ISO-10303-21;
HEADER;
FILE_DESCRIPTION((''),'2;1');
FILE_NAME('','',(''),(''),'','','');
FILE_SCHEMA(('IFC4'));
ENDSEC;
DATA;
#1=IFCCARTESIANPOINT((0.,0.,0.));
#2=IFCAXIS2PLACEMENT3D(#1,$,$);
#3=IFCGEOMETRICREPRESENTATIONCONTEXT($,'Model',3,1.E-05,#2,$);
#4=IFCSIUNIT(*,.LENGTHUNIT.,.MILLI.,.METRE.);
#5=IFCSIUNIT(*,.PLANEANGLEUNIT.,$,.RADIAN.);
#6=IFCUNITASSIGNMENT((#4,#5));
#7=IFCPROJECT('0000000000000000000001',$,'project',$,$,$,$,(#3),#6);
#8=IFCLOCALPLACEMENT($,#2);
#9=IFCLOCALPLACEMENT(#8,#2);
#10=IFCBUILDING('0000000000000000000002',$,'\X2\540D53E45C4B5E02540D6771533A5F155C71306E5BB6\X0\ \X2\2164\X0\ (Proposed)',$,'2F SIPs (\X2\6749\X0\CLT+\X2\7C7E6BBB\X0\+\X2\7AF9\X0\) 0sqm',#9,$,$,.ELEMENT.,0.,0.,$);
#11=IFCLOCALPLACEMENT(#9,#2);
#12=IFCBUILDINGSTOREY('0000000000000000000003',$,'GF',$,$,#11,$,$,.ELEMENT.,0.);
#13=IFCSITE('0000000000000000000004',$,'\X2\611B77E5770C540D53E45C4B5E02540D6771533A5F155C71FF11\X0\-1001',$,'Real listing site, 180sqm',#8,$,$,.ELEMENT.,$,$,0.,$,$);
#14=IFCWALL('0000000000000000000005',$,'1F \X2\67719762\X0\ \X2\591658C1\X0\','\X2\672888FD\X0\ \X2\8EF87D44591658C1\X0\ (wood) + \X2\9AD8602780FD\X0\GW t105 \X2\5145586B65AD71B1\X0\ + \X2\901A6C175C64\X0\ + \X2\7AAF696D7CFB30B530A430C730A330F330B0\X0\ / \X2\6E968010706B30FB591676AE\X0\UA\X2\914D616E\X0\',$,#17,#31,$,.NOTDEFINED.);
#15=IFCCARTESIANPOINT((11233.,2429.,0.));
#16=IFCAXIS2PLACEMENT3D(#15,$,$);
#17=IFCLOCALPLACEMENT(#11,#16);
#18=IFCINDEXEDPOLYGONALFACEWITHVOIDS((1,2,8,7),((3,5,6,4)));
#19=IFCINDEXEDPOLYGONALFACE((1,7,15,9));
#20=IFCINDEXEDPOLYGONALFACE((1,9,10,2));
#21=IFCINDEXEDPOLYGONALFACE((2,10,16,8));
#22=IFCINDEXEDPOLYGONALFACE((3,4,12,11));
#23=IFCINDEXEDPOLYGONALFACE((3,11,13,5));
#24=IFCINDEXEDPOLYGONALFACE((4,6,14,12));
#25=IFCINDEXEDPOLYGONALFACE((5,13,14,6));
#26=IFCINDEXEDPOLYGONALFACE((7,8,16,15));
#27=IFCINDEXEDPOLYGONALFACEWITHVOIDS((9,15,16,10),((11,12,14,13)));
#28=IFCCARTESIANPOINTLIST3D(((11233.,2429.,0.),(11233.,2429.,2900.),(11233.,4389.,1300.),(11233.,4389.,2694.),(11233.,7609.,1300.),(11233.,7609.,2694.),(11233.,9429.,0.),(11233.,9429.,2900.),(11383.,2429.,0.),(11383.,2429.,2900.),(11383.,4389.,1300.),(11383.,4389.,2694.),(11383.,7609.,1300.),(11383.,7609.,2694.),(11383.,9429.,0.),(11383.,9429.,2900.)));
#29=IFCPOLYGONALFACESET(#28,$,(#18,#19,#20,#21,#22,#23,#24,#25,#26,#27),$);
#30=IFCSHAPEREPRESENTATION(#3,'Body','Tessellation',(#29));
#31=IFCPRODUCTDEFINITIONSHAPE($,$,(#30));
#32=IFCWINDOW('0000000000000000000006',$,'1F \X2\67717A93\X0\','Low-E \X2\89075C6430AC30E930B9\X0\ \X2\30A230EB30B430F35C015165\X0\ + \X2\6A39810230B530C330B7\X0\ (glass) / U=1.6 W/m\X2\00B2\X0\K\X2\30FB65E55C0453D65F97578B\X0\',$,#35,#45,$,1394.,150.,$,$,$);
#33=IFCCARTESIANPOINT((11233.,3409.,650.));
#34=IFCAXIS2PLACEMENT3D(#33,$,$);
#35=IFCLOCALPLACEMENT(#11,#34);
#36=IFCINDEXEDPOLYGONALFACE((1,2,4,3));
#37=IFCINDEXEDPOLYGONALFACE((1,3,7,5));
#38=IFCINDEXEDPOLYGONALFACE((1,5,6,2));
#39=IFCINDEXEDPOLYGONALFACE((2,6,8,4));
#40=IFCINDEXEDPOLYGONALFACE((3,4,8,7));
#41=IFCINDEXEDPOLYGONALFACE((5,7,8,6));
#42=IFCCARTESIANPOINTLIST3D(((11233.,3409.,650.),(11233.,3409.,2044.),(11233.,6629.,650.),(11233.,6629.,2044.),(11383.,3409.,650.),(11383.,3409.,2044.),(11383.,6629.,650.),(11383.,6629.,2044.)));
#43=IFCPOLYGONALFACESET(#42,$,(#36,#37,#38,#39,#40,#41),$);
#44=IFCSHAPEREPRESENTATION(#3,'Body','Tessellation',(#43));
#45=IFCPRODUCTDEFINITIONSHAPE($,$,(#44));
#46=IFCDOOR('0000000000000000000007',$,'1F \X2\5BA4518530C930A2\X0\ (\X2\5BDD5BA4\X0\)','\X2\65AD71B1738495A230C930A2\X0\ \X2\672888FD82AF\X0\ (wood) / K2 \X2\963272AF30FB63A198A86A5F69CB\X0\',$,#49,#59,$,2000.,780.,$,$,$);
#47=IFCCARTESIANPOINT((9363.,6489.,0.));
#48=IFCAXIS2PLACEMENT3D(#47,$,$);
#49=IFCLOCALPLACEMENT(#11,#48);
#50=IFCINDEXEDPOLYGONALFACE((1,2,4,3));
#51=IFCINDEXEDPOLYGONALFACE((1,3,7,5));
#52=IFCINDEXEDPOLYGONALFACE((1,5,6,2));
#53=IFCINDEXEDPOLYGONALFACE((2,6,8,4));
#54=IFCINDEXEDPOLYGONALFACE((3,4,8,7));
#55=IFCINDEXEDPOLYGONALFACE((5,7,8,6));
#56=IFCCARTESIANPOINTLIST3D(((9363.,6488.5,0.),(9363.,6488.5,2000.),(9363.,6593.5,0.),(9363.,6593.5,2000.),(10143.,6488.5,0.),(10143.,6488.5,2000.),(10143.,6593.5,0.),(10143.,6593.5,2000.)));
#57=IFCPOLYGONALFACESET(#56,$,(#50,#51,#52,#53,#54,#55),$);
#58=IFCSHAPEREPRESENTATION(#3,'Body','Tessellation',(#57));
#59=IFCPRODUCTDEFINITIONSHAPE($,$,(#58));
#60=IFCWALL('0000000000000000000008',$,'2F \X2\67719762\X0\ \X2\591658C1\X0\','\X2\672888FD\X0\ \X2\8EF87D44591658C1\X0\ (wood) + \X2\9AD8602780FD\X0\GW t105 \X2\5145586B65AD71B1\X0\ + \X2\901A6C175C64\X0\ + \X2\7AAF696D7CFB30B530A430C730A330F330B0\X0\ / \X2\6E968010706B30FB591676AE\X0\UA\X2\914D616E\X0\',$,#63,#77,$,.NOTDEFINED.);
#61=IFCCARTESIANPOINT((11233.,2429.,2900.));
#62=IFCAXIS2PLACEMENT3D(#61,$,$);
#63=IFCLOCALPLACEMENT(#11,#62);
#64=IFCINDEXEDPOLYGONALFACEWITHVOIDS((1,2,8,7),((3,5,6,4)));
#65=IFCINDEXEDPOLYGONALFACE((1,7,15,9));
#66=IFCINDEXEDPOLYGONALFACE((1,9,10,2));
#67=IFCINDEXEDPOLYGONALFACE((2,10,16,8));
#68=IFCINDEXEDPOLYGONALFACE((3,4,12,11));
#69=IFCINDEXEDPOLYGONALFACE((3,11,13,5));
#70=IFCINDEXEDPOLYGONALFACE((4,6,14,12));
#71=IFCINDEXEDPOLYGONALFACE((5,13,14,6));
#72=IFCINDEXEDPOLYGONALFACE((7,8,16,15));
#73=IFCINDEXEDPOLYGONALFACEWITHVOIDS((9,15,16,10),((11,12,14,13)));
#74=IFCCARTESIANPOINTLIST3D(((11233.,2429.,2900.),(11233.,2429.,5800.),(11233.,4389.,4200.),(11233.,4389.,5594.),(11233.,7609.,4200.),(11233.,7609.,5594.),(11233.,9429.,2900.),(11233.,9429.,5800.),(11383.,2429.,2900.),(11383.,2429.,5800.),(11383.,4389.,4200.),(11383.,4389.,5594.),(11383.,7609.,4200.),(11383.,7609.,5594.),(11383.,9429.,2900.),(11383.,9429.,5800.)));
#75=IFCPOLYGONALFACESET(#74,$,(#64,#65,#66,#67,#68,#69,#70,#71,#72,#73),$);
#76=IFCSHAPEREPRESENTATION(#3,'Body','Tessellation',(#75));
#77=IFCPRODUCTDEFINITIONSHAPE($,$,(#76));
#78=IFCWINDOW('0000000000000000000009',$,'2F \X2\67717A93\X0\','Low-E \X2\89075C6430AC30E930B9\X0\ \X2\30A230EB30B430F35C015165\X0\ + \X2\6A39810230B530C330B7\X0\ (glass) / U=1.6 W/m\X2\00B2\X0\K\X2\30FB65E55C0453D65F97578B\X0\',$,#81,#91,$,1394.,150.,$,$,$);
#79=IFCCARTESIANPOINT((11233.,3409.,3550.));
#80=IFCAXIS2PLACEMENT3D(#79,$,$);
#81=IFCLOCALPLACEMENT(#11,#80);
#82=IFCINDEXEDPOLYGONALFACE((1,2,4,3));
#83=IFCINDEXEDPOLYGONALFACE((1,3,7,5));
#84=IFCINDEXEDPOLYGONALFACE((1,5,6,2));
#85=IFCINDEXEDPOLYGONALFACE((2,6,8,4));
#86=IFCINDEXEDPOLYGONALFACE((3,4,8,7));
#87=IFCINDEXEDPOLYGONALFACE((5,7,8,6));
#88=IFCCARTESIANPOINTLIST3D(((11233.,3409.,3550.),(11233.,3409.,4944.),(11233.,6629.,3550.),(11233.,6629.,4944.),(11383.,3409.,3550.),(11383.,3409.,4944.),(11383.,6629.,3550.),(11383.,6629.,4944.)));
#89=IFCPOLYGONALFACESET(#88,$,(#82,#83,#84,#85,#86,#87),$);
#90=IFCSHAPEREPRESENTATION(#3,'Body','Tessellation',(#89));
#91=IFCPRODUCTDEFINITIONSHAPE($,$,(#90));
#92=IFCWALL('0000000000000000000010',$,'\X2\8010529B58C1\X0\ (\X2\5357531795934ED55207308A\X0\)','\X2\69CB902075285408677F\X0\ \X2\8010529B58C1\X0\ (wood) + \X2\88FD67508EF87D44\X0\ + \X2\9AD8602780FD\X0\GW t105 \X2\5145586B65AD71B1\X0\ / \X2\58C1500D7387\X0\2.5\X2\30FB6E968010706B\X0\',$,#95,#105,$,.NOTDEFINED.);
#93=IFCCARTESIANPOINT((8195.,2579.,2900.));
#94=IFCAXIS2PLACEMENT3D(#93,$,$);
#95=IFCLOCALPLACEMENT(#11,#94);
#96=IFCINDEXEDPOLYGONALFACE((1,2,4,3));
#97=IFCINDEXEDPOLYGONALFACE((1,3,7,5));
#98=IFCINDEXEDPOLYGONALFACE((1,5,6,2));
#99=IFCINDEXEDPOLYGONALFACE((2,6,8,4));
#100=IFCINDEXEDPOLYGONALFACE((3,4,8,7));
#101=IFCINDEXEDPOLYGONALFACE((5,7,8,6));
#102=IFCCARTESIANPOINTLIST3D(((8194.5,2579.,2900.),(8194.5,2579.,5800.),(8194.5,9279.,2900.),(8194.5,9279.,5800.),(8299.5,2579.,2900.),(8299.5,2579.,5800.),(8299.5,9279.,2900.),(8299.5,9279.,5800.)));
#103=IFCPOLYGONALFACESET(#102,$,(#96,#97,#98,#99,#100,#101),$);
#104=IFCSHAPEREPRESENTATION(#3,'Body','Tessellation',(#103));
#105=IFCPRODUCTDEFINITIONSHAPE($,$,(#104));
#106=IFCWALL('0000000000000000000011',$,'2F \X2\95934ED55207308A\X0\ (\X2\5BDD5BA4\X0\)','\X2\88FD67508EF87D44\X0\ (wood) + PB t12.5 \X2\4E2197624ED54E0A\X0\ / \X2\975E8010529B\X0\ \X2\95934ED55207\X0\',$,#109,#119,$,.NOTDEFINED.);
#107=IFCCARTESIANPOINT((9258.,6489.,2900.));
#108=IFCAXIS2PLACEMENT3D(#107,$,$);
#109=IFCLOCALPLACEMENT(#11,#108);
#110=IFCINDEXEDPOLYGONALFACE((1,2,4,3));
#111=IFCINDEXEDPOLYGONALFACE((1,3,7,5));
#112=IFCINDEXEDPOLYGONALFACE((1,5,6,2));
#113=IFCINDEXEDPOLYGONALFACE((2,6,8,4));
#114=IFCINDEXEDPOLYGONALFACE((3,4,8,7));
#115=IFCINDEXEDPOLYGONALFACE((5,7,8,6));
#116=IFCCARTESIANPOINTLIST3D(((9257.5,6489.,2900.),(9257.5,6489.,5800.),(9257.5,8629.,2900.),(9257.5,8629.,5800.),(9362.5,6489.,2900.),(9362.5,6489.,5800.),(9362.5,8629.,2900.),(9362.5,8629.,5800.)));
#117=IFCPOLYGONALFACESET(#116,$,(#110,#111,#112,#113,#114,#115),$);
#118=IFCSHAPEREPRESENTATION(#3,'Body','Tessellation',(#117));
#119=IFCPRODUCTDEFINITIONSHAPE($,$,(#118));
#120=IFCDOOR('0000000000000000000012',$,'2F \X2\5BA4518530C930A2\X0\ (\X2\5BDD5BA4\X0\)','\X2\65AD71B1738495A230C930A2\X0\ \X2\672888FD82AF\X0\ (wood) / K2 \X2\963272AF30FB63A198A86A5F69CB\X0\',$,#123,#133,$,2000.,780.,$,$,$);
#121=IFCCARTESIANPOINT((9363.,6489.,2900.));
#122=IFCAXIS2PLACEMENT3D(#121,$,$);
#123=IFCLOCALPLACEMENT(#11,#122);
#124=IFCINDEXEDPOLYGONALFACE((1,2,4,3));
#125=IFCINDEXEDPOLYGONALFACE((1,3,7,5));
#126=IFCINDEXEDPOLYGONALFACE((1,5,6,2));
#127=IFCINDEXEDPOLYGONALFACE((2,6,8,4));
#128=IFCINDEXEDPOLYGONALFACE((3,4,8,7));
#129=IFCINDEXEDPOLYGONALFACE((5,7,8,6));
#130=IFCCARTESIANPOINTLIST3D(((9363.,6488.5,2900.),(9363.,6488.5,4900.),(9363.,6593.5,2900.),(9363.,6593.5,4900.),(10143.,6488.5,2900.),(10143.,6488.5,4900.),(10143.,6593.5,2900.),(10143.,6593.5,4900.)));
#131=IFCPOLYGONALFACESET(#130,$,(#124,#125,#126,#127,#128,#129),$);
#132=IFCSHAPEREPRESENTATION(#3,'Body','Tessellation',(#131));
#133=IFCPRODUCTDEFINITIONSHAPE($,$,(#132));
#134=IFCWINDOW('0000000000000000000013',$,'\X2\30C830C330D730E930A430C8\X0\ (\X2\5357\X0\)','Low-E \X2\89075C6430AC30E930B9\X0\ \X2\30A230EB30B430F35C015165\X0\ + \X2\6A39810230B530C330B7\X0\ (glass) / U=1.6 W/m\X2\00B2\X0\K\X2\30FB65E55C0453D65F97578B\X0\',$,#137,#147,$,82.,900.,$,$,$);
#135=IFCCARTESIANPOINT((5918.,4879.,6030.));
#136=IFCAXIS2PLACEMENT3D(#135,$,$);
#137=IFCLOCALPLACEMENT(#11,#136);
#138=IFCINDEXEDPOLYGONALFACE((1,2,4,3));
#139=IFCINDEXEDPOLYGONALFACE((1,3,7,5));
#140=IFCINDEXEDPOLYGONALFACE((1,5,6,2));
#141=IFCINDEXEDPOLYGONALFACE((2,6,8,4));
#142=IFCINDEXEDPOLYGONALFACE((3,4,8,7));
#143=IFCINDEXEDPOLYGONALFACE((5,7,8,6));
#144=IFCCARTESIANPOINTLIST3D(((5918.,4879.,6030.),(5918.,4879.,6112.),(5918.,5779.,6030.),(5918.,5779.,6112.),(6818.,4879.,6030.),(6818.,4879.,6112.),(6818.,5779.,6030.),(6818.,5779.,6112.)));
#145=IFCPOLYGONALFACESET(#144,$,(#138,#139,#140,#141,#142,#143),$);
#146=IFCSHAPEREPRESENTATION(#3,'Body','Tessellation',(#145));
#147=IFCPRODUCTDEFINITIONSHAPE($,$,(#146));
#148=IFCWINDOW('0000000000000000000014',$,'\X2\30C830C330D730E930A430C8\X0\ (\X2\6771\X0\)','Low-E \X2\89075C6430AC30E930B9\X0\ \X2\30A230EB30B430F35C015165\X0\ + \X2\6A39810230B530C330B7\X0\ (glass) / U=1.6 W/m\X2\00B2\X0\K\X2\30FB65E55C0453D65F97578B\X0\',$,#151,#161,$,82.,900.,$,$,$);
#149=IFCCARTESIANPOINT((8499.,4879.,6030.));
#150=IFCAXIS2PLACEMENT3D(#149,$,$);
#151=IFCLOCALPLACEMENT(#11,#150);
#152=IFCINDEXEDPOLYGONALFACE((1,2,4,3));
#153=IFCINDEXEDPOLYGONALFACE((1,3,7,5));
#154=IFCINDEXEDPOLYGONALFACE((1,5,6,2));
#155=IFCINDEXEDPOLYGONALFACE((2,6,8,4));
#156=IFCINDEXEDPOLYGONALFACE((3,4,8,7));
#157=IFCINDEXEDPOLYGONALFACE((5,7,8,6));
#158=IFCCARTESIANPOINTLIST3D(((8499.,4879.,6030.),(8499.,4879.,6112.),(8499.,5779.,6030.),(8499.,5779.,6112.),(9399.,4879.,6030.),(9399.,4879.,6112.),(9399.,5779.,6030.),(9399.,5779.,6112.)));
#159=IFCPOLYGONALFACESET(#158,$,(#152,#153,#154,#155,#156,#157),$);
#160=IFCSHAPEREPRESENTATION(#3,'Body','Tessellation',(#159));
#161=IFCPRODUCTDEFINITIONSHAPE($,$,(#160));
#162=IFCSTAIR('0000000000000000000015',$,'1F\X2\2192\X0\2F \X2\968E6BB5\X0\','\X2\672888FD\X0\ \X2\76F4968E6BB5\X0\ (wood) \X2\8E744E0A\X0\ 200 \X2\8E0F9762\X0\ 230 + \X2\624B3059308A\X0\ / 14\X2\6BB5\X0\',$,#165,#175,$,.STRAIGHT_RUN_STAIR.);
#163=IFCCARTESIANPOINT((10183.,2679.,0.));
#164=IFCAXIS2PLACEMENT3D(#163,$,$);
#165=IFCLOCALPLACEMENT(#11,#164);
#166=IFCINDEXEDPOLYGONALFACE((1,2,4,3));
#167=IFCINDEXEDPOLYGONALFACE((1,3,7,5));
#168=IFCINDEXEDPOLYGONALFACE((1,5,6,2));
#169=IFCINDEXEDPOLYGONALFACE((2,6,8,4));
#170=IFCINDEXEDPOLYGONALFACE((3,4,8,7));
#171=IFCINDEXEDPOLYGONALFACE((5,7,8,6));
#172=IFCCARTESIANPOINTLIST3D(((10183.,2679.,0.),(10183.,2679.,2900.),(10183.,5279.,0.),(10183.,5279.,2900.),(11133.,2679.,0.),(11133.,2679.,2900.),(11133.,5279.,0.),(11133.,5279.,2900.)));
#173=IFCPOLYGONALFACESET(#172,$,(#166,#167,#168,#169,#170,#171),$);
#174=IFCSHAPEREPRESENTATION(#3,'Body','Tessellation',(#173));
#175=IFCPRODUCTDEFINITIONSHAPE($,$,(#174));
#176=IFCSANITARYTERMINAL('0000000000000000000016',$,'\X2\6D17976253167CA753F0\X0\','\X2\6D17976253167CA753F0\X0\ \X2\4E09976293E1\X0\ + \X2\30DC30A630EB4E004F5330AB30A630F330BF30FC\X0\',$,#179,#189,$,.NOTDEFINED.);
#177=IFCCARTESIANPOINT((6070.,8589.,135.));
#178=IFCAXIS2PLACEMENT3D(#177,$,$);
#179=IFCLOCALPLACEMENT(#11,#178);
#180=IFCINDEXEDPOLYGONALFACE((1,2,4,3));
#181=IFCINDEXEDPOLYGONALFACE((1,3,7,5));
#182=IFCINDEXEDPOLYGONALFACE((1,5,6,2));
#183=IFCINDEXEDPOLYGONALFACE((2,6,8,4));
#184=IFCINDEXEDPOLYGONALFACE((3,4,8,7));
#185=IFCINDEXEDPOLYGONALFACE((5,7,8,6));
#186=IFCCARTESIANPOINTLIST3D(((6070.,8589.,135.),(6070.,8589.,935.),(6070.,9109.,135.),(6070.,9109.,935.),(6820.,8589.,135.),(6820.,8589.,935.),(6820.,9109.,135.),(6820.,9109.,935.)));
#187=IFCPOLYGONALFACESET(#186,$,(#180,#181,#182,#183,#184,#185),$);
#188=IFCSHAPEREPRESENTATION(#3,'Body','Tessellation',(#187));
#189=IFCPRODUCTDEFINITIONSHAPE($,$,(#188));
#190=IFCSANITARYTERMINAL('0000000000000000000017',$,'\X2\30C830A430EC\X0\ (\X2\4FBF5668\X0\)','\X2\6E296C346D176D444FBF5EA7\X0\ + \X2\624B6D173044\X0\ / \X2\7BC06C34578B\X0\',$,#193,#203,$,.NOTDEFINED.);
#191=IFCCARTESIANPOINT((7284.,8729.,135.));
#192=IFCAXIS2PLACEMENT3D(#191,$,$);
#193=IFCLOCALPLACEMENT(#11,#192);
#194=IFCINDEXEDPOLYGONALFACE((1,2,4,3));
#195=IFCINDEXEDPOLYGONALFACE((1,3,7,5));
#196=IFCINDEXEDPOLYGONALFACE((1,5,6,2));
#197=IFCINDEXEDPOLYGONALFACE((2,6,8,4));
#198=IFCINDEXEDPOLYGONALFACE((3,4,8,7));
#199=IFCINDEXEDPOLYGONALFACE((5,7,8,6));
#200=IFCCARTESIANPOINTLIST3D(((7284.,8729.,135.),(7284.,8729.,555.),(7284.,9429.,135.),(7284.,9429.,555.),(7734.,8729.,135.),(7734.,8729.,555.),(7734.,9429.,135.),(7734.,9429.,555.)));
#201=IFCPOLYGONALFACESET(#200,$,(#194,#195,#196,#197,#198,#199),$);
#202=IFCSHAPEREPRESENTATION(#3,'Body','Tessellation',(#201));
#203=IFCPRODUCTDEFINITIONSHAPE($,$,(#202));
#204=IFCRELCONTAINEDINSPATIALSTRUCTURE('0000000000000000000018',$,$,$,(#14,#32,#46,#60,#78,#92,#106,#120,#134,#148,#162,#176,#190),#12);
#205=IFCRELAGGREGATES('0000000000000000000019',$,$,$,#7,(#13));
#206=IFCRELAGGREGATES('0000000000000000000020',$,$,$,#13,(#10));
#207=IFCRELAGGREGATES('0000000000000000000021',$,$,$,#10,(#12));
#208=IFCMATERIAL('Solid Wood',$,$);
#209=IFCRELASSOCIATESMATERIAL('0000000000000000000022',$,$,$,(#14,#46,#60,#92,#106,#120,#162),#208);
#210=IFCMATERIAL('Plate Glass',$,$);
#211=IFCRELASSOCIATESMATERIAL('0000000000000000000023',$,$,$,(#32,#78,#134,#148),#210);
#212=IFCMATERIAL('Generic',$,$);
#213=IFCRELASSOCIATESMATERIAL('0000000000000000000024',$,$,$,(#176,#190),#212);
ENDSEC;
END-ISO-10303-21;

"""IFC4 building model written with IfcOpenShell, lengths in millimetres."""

from ifc_helpers import new_model, si_unit, frame, frame_2d, origin, place, context, project, spatial, rectangle, extrude, material, element, fill, save


model = new_model("IFC4")

# Units and contexts
model_context = context("Model", 3, precision=1e-05, world=origin())
ifc_project = project(units=[si_unit("LENGTHUNIT", "METRE", prefix="MILLI"), si_unit("PLANEANGLEUNIT", "RADIAN")], contexts=[model_context])

# Site, building, storey
site_placement = place(None, origin())
site = spatial("IfcSite", under=ifc_project, at=site_placement, Name="愛知県名古屋市名東区引山１-1001", ObjectType="Real listing site, 180sqm", CompositionType="ELEMENT", RefElevation=0.0)
building_placement = place(site_placement, origin())
building = spatial("IfcBuilding", under=site, at=building_placement, Name="名古屋市名東区引山の家 Ⅴ (Proposed)", ObjectType="2F SIPs (杉CLT+籾殻+竹) 0sqm", CompositionType="ELEMENT", ElevationOfRefHeight=0.0, ElevationOfTerrain=0.0)
storey_placement = place(building_placement, origin())
storey = spatial("IfcBuildingStorey", under=building, at=storey_placement, Name="GF", CompositionType="ELEMENT", Elevation=0.0)

# Wall, opening, window
ifc_material_1 = material(Name="Solid Wood")
wall_1_placement = place(storey_placement, frame((11233.0, 2429.0, 0.0)))
wall_1 = element("IfcWall", 1, at=wall_1_placement, inside=storey, material=ifc_material_1, Name="1F 東面 外壁", Description="木製 軸組外壁 (wood) + 高性能GW t105 充填断熱 + 通気層 + 窯業系サイディング / 準耐火・外皮UA配慮", PredefinedType="NOTDEFINED", context=model_context, shape_type="SweptSolid", body=[
    extrude(rectangle(XDim=150.0, YDim=7000.0, at=frame_2d((75.0, 3500.0))), frame((11233.0, 2429.0, 0.0)), (0.0, 0.0, 1.0), 2900.0),
])
opening_1_placement = place(storey_placement, frame((11233.0, 3409.0, 650.0)))
opening_1 = element("IfcOpeningElement", 2, at=opening_1_placement, cuts=wall_1, PredefinedType="NOTDEFINED", context=model_context, shape_type="SweptSolid", body=[
    extrude(rectangle(XDim=150.0, YDim=3220.0, at=frame_2d((75.0, 1610.0))), frame((11233.0, 3409.0, 650.0)), (0.0, 0.0, 1.0), 1394.0),
])
ifc_material_2 = material(Name="Plate Glass")
window_1_placement = place(storey_placement, frame((11233.0, 3409.0, 650.0)))
window_1 = element("IfcWindow", 3, at=window_1_placement, inside=storey, material=ifc_material_2, Name="1F 東窓", Description="Low-E 複層ガラス アルゴン封入 + 樹脂サッシ (glass) / U=1.6 W/m²K・日射取得型", OverallHeight=1394.0, OverallWidth=150.0, context=model_context, shape_type="SweptSolid", body=[
    extrude(rectangle(XDim=150.0, YDim=3220.0, at=frame_2d((75.0, 1610.0))), frame((11233.0, 3409.0, 650.0)), (0.0, 0.0, 1.0), 1394.0),
])
fill(opening_1, window_1)

# Door
door_1_placement = place(storey_placement, frame((9363.0, 6489.0, 0.0)))
element("IfcDoor", 4, at=door_1_placement, inside=storey, material=ifc_material_1, Name="1F 室内ドア (寝室)", Description="断熱玄関ドア 木製芯 (wood) / K2 防犯・採風機構", OverallHeight=2000.0, OverallWidth=780.0, context=model_context, shape_type="SweptSolid", body=[
    extrude(rectangle(XDim=780.0, YDim=105.0, at=frame_2d((390.0, 52.0))), frame((9363.0, 6489.0, 0.0)), (0.0, 0.0, 1.0), 2000.0),
])

# Wall, opening, window
wall_2_placement = place(storey_placement, frame((11233.0, 2429.0, 2900.0)))
wall_2 = element("IfcWall", 5, at=wall_2_placement, inside=storey, material=ifc_material_1, Name="2F 東面 外壁", Description="木製 軸組外壁 (wood) + 高性能GW t105 充填断熱 + 通気層 + 窯業系サイディング / 準耐火・外皮UA配慮", PredefinedType="NOTDEFINED", context=model_context, shape_type="SweptSolid", body=[
    extrude(rectangle(XDim=150.0, YDim=7000.0, at=frame_2d((75.0, 3500.0))), frame((11233.0, 2429.0, 2900.0)), (0.0, 0.0, 1.0), 2900.0),
])
opening_2_placement = place(storey_placement, frame((11233.0, 3409.0, 3550.0)))
opening_2 = element("IfcOpeningElement", 6, at=opening_2_placement, cuts=wall_2, PredefinedType="NOTDEFINED", context=model_context, shape_type="SweptSolid", body=[
    extrude(rectangle(XDim=150.0, YDim=3220.0, at=frame_2d((75.0, 1610.0))), frame((11233.0, 3409.0, 3550.0)), (0.0, 0.0, 1.0), 1394.0),
])
window_2_placement = place(storey_placement, frame((11233.0, 3409.0, 3550.0)))
window_2 = element("IfcWindow", 7, at=window_2_placement, inside=storey, material=ifc_material_2, Name="2F 東窓", Description="Low-E 複層ガラス アルゴン封入 + 樹脂サッシ (glass) / U=1.6 W/m²K・日射取得型", OverallHeight=1394.0, OverallWidth=150.0, context=model_context, shape_type="SweptSolid", body=[
    extrude(rectangle(XDim=150.0, YDim=3220.0, at=frame_2d((75.0, 1610.0))), frame((11233.0, 3409.0, 3550.0)), (0.0, 0.0, 1.0), 1394.0),
])
fill(opening_2, window_2)

# Walls
wall_3_placement = place(storey_placement, frame((8195.0, 2579.0, 2900.0)))
element("IfcWall", 8, at=wall_3_placement, inside=storey, material=ifc_material_1, Name="耐力壁 (南北間仕切り)", Description="構造用合板 耐力壁 (wood) + 製材軸組 + 高性能GW t105 充填断熱 / 壁倍率2.5・準耐火", PredefinedType="NOTDEFINED", context=model_context, shape_type="SweptSolid", body=[
    extrude(rectangle(XDim=105.0, YDim=6700.0, at=frame_2d((52.0, 3350.0))), frame((8195.0, 2579.0, 2900.0)), (0.0, 0.0, 1.0), 2900.0),
])
wall_4_placement = place(storey_placement, frame((9258.0, 6489.0, 2900.0)))
element("IfcWall", 9, at=wall_4_placement, inside=storey, material=ifc_material_1, Name="2F 間仕切り (寝室)", Description="製材軸組 (wood) + PB t12.5 両面仕上 / 非耐力 間仕切", PredefinedType="NOTDEFINED", context=model_context, shape_type="SweptSolid", body=[
    extrude(rectangle(XDim=105.0, YDim=2140.0, at=frame_2d((52.0, 1070.0))), frame((9258.0, 6489.0, 2900.0)), (0.0, 0.0, 1.0), 2900.0),
])

# Door
door_2_placement = place(storey_placement, frame((9363.0, 6489.0, 2900.0)))
element("IfcDoor", 10, at=door_2_placement, inside=storey, material=ifc_material_1, Name="2F 室内ドア (寝室)", Description="断熱玄関ドア 木製芯 (wood) / K2 防犯・採風機構", OverallHeight=2000.0, OverallWidth=780.0, context=model_context, shape_type="SweptSolid", body=[
    extrude(rectangle(XDim=780.0, YDim=105.0, at=frame_2d((390.0, 52.0))), frame((9363.0, 6489.0, 2900.0)), (0.0, 0.0, 1.0), 2000.0),
])

# Windows
window_3_placement = place(storey_placement, frame((5918.0, 4879.0, 6030.0)))
element("IfcWindow", 11, at=window_3_placement, inside=storey, material=ifc_material_2, Name="トップライト (南)", Description="Low-E 複層ガラス アルゴン封入 + 樹脂サッシ (glass) / U=1.6 W/m²K・日射取得型", OverallHeight=82.0, OverallWidth=900.0, context=model_context, shape_type="SweptSolid", body=[
    extrude(rectangle(XDim=900.0, YDim=900.0, at=frame_2d((450.0, 450.0))), frame((5918.0, 4879.0, 6030.0)), (0.0, 0.0, 1.0), 82.0),
])
window_4_placement = place(storey_placement, frame((8499.0, 4879.0, 6030.0)))
element("IfcWindow", 12, at=window_4_placement, inside=storey, material=ifc_material_2, Name="トップライト (東)", Description="Low-E 複層ガラス アルゴン封入 + 樹脂サッシ (glass) / U=1.6 W/m²K・日射取得型", OverallHeight=82.0, OverallWidth=900.0, context=model_context, shape_type="SweptSolid", body=[
    extrude(rectangle(XDim=900.0, YDim=900.0, at=frame_2d((450.0, 450.0))), frame((8499.0, 4879.0, 6030.0)), (0.0, 0.0, 1.0), 82.0),
])

# Stair
stair_placement = place(storey_placement, frame((10183.0, 2679.0, 0.0)))
element("IfcStair", 13, at=stair_placement, inside=storey, material=ifc_material_1, Name="1F→2F 階段", Description="木製 直階段 (wood) 蹴上 200 踏面 230 + 手すり / 14段", PredefinedType="STRAIGHT_RUN_STAIR", context=model_context, shape_type="SweptSolid", body=[
    extrude(rectangle(XDim=950.0, YDim=2600.0, at=frame_2d((475.0, 1300.0))), frame((10183.0, 2679.0, 0.0)), (0.0, 0.0, 1.0), 2900.0),
])

# Sanitary terminals
ifc_material_3 = material(Name="Generic")
sanitary_terminal_1_placement = place(storey_placement, frame((6070.0, 8589.0, 135.0)))
element("IfcSanitaryTerminal", 14, at=sanitary_terminal_1_placement, inside=storey, material=ifc_material_3, Name="洗面化粧台", Description="洗面化粧台 三面鏡 + ボウル一体カウンター", PredefinedType="NOTDEFINED", context=model_context, shape_type="SweptSolid", body=[
    extrude(rectangle(XDim=750.0, YDim=520.0, at=frame_2d((375.0, 260.0))), frame((6070.0, 8589.0, 135.0)), (0.0, 0.0, 1.0), 800.0),
])
sanitary_terminal_2_placement = place(storey_placement, frame((7284.0, 8729.0, 135.0)))
element("IfcSanitaryTerminal", 15, at=sanitary_terminal_2_placement, inside=storey, material=ifc_material_3, Name="トイレ (便器)", Description="温水洗浄便座 + 手洗い / 節水型", PredefinedType="NOTDEFINED", context=model_context, shape_type="SweptSolid", body=[
    extrude(rectangle(XDim=450.0, YDim=700.0, at=frame_2d((225.0, 350.0))), frame((7284.0, 8729.0, 135.0)), (0.0, 0.0, 1.0), 420.0),
])

save(model, "model.ifc")
